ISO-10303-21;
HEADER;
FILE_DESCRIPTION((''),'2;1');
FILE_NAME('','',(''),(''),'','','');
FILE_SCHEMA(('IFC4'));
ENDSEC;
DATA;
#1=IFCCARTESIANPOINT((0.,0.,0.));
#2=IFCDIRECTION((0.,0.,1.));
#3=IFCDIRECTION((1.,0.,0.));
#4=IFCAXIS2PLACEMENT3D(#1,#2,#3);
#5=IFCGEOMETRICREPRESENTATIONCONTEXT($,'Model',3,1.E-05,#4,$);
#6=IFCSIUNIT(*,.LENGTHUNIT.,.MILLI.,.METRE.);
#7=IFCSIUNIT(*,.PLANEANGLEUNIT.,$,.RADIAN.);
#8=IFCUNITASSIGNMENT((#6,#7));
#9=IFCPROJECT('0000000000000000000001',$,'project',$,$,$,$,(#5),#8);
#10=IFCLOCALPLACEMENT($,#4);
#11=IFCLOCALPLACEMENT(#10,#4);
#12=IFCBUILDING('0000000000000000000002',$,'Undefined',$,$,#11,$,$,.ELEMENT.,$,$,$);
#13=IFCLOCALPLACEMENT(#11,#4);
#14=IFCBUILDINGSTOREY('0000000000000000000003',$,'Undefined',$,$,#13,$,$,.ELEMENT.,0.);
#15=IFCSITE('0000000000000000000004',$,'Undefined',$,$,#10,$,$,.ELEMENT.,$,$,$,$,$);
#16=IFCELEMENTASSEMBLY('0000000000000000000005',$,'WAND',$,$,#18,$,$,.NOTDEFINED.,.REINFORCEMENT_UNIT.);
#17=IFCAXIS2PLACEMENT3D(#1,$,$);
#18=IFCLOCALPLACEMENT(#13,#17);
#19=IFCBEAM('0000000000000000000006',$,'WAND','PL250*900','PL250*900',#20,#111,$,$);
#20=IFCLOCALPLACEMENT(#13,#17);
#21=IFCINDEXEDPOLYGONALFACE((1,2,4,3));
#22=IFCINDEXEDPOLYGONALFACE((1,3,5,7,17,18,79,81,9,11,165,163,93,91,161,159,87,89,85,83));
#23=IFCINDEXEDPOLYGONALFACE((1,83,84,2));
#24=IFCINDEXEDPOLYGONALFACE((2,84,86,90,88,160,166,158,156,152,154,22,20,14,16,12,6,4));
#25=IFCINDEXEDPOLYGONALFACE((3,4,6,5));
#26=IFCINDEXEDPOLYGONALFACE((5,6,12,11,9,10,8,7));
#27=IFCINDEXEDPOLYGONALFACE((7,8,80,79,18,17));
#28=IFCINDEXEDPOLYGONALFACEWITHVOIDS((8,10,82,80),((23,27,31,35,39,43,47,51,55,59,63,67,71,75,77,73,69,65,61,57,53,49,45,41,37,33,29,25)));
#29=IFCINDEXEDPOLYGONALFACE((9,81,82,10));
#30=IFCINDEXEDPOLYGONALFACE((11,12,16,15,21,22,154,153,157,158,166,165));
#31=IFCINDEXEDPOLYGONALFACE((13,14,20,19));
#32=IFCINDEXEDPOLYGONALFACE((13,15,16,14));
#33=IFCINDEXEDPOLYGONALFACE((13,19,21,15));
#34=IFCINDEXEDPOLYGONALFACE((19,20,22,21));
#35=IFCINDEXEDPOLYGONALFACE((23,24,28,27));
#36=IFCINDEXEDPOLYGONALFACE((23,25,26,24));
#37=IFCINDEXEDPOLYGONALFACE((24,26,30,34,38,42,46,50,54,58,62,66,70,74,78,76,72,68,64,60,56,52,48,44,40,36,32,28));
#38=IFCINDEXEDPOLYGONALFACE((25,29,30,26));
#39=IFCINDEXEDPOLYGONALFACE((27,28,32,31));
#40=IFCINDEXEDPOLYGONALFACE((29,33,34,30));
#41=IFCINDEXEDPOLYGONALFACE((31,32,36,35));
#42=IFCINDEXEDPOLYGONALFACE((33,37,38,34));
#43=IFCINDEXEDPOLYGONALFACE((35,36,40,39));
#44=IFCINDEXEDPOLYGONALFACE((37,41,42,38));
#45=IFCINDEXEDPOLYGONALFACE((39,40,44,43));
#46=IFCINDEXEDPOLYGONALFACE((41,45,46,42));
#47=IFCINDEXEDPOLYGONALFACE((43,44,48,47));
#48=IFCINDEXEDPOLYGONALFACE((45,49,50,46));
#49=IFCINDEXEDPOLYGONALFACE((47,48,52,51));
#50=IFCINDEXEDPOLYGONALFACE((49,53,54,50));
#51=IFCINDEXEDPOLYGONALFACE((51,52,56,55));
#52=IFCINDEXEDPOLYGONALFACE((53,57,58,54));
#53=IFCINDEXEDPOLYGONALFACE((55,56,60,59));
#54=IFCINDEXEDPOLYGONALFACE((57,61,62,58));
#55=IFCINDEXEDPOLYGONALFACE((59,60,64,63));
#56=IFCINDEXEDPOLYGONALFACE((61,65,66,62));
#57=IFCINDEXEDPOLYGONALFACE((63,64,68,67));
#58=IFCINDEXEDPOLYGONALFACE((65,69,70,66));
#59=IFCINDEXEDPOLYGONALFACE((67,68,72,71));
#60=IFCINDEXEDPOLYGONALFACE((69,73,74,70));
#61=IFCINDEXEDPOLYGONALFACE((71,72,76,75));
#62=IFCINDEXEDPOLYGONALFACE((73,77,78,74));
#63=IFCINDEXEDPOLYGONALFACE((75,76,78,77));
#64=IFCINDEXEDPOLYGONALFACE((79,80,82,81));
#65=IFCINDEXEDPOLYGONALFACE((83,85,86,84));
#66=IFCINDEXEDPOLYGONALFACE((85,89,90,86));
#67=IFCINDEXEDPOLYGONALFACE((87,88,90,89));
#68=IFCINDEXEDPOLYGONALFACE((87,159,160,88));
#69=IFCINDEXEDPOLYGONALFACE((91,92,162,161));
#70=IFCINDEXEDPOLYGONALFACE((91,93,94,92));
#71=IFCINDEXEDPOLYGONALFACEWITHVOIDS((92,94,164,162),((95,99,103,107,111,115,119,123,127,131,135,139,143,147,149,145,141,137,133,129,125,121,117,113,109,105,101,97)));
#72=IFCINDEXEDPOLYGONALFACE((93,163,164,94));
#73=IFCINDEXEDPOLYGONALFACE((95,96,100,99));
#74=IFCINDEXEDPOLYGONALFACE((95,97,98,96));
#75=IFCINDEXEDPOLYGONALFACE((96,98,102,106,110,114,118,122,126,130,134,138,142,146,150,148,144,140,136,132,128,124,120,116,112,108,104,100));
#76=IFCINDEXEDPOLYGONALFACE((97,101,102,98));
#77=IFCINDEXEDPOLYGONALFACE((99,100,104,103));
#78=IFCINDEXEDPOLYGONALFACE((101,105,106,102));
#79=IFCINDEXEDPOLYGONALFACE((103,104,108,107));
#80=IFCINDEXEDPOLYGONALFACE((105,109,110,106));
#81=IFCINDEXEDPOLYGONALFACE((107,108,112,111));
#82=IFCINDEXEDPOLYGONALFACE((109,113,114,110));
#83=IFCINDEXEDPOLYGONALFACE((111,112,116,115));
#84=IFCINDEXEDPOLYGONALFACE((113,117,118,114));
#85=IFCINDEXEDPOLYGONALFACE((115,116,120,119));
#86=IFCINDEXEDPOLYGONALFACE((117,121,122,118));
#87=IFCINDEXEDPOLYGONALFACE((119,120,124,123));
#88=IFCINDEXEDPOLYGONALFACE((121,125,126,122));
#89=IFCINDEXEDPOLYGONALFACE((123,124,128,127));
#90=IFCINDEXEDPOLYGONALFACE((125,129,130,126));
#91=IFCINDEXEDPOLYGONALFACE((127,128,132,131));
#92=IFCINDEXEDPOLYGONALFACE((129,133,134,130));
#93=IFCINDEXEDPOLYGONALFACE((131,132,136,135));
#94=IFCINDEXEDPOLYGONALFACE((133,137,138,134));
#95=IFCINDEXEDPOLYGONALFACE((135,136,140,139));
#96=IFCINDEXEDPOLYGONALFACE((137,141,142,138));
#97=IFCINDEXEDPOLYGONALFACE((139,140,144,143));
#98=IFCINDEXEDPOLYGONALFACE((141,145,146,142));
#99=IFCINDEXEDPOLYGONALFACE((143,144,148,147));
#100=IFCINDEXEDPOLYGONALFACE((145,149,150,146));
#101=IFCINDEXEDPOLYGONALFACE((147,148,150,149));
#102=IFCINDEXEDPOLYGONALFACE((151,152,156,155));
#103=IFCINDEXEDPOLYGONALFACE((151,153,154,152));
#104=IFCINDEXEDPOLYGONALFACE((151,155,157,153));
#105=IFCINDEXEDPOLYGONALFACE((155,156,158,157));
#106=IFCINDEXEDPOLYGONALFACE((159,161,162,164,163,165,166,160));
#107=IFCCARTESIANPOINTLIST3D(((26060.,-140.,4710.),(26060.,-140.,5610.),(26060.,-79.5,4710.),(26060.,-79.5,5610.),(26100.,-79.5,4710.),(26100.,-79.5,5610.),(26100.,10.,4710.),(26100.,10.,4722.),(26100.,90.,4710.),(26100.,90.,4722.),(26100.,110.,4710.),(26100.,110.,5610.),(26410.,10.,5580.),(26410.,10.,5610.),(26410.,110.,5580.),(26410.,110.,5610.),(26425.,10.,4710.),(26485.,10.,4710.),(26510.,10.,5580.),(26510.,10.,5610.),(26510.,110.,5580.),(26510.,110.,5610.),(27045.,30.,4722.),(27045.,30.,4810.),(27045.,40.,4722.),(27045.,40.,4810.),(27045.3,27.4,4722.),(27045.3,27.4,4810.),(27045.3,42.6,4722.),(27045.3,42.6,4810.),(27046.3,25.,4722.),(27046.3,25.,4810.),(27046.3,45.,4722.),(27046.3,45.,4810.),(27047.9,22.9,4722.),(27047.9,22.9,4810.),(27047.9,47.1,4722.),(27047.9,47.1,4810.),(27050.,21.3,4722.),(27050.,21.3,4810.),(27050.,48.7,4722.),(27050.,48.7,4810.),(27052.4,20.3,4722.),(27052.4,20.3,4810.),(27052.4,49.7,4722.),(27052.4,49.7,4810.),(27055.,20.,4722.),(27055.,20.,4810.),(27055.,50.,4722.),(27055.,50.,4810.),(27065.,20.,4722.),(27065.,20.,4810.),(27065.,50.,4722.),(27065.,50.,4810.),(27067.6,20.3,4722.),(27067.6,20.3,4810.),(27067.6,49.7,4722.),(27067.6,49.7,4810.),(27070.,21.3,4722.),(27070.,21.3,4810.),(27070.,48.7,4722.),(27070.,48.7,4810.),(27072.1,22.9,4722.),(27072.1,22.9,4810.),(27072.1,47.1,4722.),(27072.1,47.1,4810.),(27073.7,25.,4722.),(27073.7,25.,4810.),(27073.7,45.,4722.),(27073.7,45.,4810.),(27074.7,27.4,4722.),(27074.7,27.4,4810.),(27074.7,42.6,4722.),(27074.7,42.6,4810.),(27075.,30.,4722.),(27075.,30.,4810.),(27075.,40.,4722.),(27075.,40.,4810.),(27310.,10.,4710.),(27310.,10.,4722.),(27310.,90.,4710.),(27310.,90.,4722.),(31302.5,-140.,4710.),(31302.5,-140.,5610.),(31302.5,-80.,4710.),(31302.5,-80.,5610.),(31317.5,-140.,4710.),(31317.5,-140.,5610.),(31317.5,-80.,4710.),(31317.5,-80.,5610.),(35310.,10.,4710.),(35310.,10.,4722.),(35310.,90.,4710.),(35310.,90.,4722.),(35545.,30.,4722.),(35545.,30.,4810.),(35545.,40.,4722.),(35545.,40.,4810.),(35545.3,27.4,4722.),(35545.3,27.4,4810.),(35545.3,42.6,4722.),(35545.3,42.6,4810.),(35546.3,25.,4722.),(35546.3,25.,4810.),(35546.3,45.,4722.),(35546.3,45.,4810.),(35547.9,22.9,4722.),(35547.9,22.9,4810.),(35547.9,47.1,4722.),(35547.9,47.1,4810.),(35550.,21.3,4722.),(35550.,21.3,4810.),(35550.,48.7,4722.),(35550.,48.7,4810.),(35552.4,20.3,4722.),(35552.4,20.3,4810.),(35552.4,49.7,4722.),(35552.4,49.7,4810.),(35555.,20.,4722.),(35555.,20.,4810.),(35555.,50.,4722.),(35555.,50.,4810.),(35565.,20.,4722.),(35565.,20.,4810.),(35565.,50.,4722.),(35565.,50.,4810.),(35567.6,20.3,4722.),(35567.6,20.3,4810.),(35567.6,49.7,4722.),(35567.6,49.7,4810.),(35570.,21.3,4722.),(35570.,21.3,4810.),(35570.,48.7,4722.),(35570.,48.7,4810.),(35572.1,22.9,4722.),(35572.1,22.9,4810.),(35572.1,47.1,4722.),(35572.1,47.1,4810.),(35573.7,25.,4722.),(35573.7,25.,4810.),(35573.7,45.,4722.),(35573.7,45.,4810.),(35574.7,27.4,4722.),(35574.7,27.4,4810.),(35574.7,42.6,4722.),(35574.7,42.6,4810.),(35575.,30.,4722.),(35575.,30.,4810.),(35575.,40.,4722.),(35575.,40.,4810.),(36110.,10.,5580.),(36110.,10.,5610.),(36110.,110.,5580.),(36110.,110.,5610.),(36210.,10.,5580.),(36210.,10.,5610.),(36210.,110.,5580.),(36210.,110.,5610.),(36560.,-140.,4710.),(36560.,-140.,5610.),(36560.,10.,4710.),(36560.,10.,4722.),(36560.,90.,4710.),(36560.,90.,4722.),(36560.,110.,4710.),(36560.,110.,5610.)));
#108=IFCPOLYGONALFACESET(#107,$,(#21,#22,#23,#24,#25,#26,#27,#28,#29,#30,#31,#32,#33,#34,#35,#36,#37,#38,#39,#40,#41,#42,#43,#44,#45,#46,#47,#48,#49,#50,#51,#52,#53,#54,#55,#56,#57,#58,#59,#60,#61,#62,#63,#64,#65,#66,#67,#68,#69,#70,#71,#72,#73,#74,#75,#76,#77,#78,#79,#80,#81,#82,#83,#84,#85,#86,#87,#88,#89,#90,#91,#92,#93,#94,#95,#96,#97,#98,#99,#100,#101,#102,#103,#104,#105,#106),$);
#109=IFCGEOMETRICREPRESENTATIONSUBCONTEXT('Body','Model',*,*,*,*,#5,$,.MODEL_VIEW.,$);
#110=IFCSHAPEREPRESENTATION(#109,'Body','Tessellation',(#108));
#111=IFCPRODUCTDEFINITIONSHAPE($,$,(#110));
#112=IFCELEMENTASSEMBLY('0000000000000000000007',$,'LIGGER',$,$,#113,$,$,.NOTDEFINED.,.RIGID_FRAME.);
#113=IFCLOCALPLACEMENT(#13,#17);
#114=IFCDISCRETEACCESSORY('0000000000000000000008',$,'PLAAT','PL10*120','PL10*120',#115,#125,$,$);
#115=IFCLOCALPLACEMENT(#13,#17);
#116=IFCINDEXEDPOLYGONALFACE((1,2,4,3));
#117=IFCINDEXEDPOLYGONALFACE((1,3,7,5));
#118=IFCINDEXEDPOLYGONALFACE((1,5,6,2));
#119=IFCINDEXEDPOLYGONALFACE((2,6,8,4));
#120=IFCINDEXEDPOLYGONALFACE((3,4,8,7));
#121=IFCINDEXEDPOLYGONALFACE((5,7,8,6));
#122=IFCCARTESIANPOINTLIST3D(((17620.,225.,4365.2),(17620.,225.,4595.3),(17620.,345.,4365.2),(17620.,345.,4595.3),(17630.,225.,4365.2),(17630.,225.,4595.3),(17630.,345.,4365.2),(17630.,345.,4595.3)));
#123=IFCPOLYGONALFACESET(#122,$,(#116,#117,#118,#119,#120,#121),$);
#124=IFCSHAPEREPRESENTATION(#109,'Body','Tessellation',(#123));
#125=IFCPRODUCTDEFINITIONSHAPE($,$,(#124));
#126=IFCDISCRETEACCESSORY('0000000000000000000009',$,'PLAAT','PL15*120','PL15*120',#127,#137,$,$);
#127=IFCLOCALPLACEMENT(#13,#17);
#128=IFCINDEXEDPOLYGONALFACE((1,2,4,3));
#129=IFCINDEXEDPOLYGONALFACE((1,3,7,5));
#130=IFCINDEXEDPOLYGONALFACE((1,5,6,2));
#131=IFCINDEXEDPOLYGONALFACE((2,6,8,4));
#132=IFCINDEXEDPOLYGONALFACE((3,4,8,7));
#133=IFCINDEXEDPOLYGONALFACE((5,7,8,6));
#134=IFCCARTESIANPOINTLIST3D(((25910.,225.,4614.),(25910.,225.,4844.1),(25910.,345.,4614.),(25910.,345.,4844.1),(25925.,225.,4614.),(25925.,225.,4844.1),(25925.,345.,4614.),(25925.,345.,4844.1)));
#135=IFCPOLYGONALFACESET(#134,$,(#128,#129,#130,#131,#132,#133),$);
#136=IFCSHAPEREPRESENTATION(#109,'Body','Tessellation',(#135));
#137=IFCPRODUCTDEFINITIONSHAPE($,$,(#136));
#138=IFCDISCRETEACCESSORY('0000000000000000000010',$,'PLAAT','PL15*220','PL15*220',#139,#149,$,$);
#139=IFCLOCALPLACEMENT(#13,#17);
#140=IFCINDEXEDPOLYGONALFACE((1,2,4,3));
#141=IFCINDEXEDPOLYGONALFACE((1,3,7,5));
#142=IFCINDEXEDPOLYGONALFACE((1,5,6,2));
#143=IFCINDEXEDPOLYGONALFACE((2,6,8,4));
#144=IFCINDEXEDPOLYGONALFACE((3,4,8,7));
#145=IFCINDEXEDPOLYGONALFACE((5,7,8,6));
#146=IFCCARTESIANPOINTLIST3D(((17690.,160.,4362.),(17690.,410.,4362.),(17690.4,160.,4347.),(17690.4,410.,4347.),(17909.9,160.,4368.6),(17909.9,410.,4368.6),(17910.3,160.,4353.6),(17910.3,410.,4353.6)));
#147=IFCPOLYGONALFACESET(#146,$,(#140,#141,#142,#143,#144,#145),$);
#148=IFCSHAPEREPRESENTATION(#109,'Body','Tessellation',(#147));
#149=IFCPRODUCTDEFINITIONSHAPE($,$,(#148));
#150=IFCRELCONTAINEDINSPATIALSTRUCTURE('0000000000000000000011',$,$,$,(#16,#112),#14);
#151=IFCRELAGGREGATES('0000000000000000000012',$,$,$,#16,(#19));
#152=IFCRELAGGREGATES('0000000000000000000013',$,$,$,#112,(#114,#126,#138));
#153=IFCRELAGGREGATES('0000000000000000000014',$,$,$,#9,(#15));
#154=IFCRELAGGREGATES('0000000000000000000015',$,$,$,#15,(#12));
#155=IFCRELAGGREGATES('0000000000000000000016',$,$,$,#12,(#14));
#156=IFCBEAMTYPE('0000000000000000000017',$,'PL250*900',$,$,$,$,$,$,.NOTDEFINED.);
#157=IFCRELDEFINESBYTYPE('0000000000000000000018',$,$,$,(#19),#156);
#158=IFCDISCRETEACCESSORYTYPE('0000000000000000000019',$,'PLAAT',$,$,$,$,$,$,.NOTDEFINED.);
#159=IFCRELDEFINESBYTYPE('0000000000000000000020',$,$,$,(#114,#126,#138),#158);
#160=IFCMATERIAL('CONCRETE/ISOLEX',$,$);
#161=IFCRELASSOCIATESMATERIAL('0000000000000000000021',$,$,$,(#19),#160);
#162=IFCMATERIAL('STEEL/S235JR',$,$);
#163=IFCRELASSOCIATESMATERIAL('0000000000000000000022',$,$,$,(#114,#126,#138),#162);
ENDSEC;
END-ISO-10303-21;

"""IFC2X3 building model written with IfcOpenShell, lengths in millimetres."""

from ifc_helpers import new_model, si_unit, frame, frame_2d, origin_with_axes, place, context, subcontext, project, spatial, polyline, circle_curve, parameter, trimmed, segment, composite_curve, rectangle, outline, extrude, boolean, material, type_object, element, aggregate, save


model = new_model("IFC2X3")

# Units and contexts
model_context = context("Model", 3, precision=1e-05, world=origin_with_axes())
body_context = subcontext(model_context, "Body", "Model", "MODEL_VIEW")
ifc_project = project(units=[si_unit("LENGTHUNIT", "METRE", prefix="MILLI"), si_unit("PLANEANGLEUNIT", "RADIAN")], contexts=[model_context])

# Site, building, storey
site_placement = place(None, origin_with_axes())
site = spatial("IfcSite", under=ifc_project, at=site_placement, Name="Undefined", CompositionType="ELEMENT")
building_placement = place(site_placement, origin_with_axes())
building = spatial("IfcBuilding", under=site, at=building_placement, Name="Undefined", CompositionType="ELEMENT")
storey_placement = place(building_placement, origin_with_axes())
storey = spatial("IfcBuildingStorey", under=building, at=storey_placement, Name="Undefined", CompositionType="ELEMENT", Elevation=0.0)

# Shared definitions
ifc_material_1 = material(Name="CONCRETE/ISOLEX")
ifc_material_2 = material(Name="STEEL/S235JR")

# Element assembly, beam
assembly_1_placement = place(storey_placement, origin_with_axes())
assembly_1 = element("IfcElementAssembly", 1, at=assembly_1_placement, inside=storey, Name="WAND", AssemblyPlace="NOTDEFINED", PredefinedType="REINFORCEMENT_UNIT")
beam_type_1 = type_object("IfcBeamType", Name="PL250*900", PredefinedType="NOTDEFINED")
beam_1_placement = place(assembly_1_placement, frame((26060.0, -15.0, 5160.0), z_axis=(0.0, 0.0, 1.0), x_axis=(1.0, 0.0, 0.0)))
solid = boolean("DIFFERENCE", boolean("DIFFERENCE", boolean("DIFFERENCE", boolean("DIFFERENCE", boolean("DIFFERENCE", boolean("DIFFERENCE", boolean("DIFFERENCE", boolean("DIFFERENCE", extrude(rectangle(XDim=250.0, YDim=900.0, at=frame_2d((0.0, 0.0), x_axis=(1.0, 0.0))), frame((10500.0, 0.0, 0.0), z_axis=(-1.0, 0.0, 0.0), x_axis=(0.0, -1.0, 0.0)), (0.0, 0.0, 1.0), 10500.0), extrude(outline(composite_curve([segment(trimmed(circle_curve(frame_2d((10.0, 10.0), x_axis=(-1.0, 0.0)), 10.0), [parameter(0.0)], [parameter(1.570796)], True, "PARAMETER"), True, "CONTINUOUS"), segment(polyline([(10.0, 0.0), (20.0, 0.0)]), True, "CONTINUOUS"), segment(trimmed(circle_curve(frame_2d((20.0, 10.0), x_axis=(0.0, -1.0)), 10.0), [parameter(0.0)], [parameter(1.570796)], True, "PARAMETER"), True, "CONTINUOUS"), segment(polyline([(30.0, 10.0), (30.0, 20.0)]), True, "CONTINUOUS"), segment(trimmed(circle_curve(frame_2d((20.0, 20.0), x_axis=(1.0, 0.0)), 10.0), [parameter(0.0)], [parameter(1.570796)], True, "PARAMETER"), True, "CONTINUOUS"), segment(polyline([(20.0, 30.0), (10.0, 30.0)]), True, "CONTINUOUS"), segment(trimmed(circle_curve(frame_2d((10.0, 20.0), x_axis=(0.0, 1.0)), 10.0), [parameter(0.0)], [parameter(1.570796)], True, "PARAMETER"), True, "CONTINUOUS"), segment(polyline([(0.0, 20.0), (0.0, 10.0)]), True, "CONTINUOUS")], self_intersect=True)), frame((985.0, 65.0, -450.0), z_axis=(0.0, 0.0, 1.0), x_axis=(0.0, -1.0, 0.0)), (0.0, 0.0, 1.0), 100.0)), extrude(outline(composite_curve([segment(trimmed(circle_curve(frame_2d((10.0, 10.0), x_axis=(-1.0, 0.0)), 10.0), [parameter(0.0)], [parameter(1.570796)], True, "PARAMETER"), True, "CONTINUOUS"), segment(polyline([(10.0, 0.0), (40.0, 0.0)]), True, "CONTINUOUS"), segment(trimmed(circle_curve(frame_2d((40.0, 10.0), x_axis=(0.0, -1.0)), 10.0), [parameter(0.0)], [parameter(1.570796)], True, "PARAMETER"), True, "CONTINUOUS"), segment(polyline([(50.0, 10.0), (50.0, 70.0)]), True, "CONTINUOUS"), segment(trimmed(circle_curve(frame_2d((40.0, 70.0), x_axis=(1.0, 0.0)), 10.0), [parameter(0.0)], [parameter(1.570796)], True, "PARAMETER"), True, "CONTINUOUS"), segment(polyline([(40.0, 80.0), (10.0, 80.0)]), True, "CONTINUOUS"), segment(trimmed(circle_curve(frame_2d((10.0, 70.0), x_axis=(0.0, 1.0)), 10.0), [parameter(0.0)], [parameter(1.570796)], True, "PARAMETER"), True, "CONTINUOUS"), segment(polyline([(0.0, 70.0), (0.0, 10.0)]), True, "CONTINUOUS")], self_intersect=True)), frame((355.0, 75.0, -600.0), z_axis=(0.0, 0.0, 1.0), x_axis=(0.0, -1.0, 0.0)), (0.0, 0.0, 1.0), 150.0)), extrude(rectangle(XDim=40.0, YDim=190.0, at=frame_2d((0.0, 0.0), x_axis=(1.0, 0.0))), frame((20.0, 30.5, 450.0), z_axis=(0.0, 0.0, -1.0), x_axis=(1.0, 0.0, 0.0)), (0.0, 0.0, 1.0), 900.0)), extrude(rectangle(XDim=100.0, YDim=100.0, at=frame_2d((0.0, 0.0), x_axis=(1.0, 0.0))), frame((400.0, 75.0, 420.0), z_axis=(0.0, 0.0, 1.0), x_axis=(-1.0, 0.0, 0.0)), (0.0, 0.0, 1.0), 30.0)), extrude(rectangle(XDim=15.0, YDim=62.0, at=frame_2d((0.0, 0.0), x_axis=(1.0, 0.0))), frame((5250.0, -96.0, 450.0), z_axis=(0.0, 0.0, -1.0), x_axis=(1.0, 0.0, 0.0)), (0.0, 0.0, 1.0), 900.0)), extrude(outline(composite_curve([segment(trimmed(circle_curve(frame_2d((10.0, 10.0), x_axis=(-1.0, 0.0)), 10.0), [parameter(0.0)], [parameter(1.570796)], True, "PARAMETER"), True, "CONTINUOUS"), segment(polyline([(10.0, 0.0), (20.0, 0.0)]), True, "CONTINUOUS"), segment(trimmed(circle_curve(frame_2d((20.0, 10.0), x_axis=(0.0, -1.0)), 10.0), [parameter(0.0)], [parameter(1.570796)], True, "PARAMETER"), True, "CONTINUOUS"), segment(polyline([(30.0, 10.0), (30.0, 20.0)]), True, "CONTINUOUS"), segment(trimmed(circle_curve(frame_2d((20.0, 20.0), x_axis=(1.0, 0.0)), 10.0), [parameter(0.0)], [parameter(1.570796)], True, "PARAMETER"), True, "CONTINUOUS"), segment(polyline([(20.0, 30.0), (10.0, 30.0)]), True, "CONTINUOUS"), segment(trimmed(circle_curve(frame_2d((10.0, 20.0), x_axis=(0.0, 1.0)), 10.0), [parameter(0.0)], [parameter(1.570796)], True, "PARAMETER"), True, "CONTINUOUS"), segment(polyline([(0.0, 20.0), (0.0, 10.0)]), True, "CONTINUOUS")], self_intersect=True)), frame((9515.0, 35.0, -450.0), z_axis=(0.0, 0.0, 1.0), x_axis=(0.0, 1.0, 0.0)), (0.0, 0.0, 1.0), 100.0)), extrude(rectangle(XDim=12.0, YDim=80.0, at=frame_2d((0.0, 0.0), x_axis=(1.0, 0.0))), frame((1250.0, 65.0, -444.0), z_axis=(-1.0, 0.0, 0.0), x_axis=(0.0, 0.0, -1.0)), (0.0, 0.0, 1.0), 1250.0)), extrude(rectangle(XDim=100.0, YDim=100.0, at=frame_2d((0.0, 0.0), x_axis=(1.0, 0.0))), frame((10100.0, 75.0, 420.0), z_axis=(0.0, 0.0, 1.0), x_axis=(-1.0, 0.0, 0.0)), (0.0, 0.0, 1.0), 30.0))
beam_1 = element("IfcBeam", 2, at=beam_1_placement, type_object=beam_type_1, material=ifc_material_1, Name="WAND", Description="PL250*900", ObjectType="PL250*900", context=body_context, shape_type="CSG", body=[
    boolean("DIFFERENCE", solid, extrude(rectangle(XDim=12.0, YDim=80.0, at=frame_2d((0.0, 0.0), x_axis=(1.0, 0.0))), frame((10500.0, 65.0, -444.0), z_axis=(-1.0, 0.0, 0.0), x_axis=(0.0, 0.0, -1.0)), (0.0, 0.0, 1.0), 1250.0)),
])
aggregate(assembly_1, [beam_1])

# Element assembly, discrete accessories
assembly_2_placement = place(storey_placement, origin_with_axes())
assembly_2 = element("IfcElementAssembly", 3, at=assembly_2_placement, inside=storey, Name="LIGGER", AssemblyPlace="NOTDEFINED", PredefinedType="RIGID_FRAME")
discrete_accessory_type_1 = type_object("IfcDiscreteAccessoryType", Name="PLAAT")
discrete_accessory_1_placement = place(assembly_2_placement, frame((17625.0, 285.0, 4365.2), z_axis=(0.0, -1.0, 0.0), x_axis=(0.0, 0.0, 1.0)))
discrete_accessory_1 = element("IfcDiscreteAccessory", 4, at=discrete_accessory_1_placement, type_object=discrete_accessory_type_1, material=ifc_material_2, Name="PLAAT", Description="PL10*120", ObjectType="PL10*120", context=body_context, shape_type="SweptSolid", body=[
    extrude(rectangle(XDim=10.0, YDim=120.0, at=frame_2d((0.0, 0.0), x_axis=(1.0, 0.0))), frame((230.1, 0.0, 0.0), z_axis=(-1.0, 0.0, 0.0), x_axis=(0.0, -1.0, 0.0)), (0.0, 0.0, 1.0), 230.1),
])
discrete_accessory_2_placement = place(assembly_2_placement, frame((25917.5, 285.0, 4844.1), z_axis=(0.0, -1.0, 0.0), x_axis=(0.0, 0.0, -1.0)))
discrete_accessory_2 = element("IfcDiscreteAccessory", 5, at=discrete_accessory_2_placement, type_object=discrete_accessory_type_1, material=ifc_material_2, Name="PLAAT", Description="PL15*120", ObjectType="PL15*120", context=body_context, shape_type="SweptSolid", body=[
    extrude(rectangle(XDim=15.0, YDim=120.0, at=frame_2d((0.0, 0.0), x_axis=(1.0, 0.0))), frame((230.1, 0.0, 0.0), z_axis=(-1.0, 0.0, 0.0), x_axis=(0.0, -1.0, 0.0)), (0.0, 0.0, 1.0), 230.1),
])
discrete_accessory_3_placement = place(assembly_2_placement, frame((17800.1, 160.0, 4357.8), z_axis=(-0.99955, 0.0, -0.029987), x_axis=(0.0, 1.0, 0.0)))
discrete_accessory_3 = element("IfcDiscreteAccessory", 6, at=discrete_accessory_3_placement, type_object=discrete_accessory_type_1, material=ifc_material_2, Name="PLAAT", Description="PL15*220", ObjectType="PL15*220", context=body_context, shape_type="SweptSolid", body=[
    extrude(rectangle(XDim=15.0, YDim=220.0, at=frame_2d((0.0, 0.0), x_axis=(1.0, 0.0))), frame((250.0, 0.0, 0.0), z_axis=(-1.0, 0.0, 0.0), x_axis=(0.0, -1.0, 0.0)), (0.0, 0.0, 1.0), 250.0),
])
aggregate(assembly_2, [discrete_accessory_1, discrete_accessory_2, discrete_accessory_3])

save(model, "model.ifc")
